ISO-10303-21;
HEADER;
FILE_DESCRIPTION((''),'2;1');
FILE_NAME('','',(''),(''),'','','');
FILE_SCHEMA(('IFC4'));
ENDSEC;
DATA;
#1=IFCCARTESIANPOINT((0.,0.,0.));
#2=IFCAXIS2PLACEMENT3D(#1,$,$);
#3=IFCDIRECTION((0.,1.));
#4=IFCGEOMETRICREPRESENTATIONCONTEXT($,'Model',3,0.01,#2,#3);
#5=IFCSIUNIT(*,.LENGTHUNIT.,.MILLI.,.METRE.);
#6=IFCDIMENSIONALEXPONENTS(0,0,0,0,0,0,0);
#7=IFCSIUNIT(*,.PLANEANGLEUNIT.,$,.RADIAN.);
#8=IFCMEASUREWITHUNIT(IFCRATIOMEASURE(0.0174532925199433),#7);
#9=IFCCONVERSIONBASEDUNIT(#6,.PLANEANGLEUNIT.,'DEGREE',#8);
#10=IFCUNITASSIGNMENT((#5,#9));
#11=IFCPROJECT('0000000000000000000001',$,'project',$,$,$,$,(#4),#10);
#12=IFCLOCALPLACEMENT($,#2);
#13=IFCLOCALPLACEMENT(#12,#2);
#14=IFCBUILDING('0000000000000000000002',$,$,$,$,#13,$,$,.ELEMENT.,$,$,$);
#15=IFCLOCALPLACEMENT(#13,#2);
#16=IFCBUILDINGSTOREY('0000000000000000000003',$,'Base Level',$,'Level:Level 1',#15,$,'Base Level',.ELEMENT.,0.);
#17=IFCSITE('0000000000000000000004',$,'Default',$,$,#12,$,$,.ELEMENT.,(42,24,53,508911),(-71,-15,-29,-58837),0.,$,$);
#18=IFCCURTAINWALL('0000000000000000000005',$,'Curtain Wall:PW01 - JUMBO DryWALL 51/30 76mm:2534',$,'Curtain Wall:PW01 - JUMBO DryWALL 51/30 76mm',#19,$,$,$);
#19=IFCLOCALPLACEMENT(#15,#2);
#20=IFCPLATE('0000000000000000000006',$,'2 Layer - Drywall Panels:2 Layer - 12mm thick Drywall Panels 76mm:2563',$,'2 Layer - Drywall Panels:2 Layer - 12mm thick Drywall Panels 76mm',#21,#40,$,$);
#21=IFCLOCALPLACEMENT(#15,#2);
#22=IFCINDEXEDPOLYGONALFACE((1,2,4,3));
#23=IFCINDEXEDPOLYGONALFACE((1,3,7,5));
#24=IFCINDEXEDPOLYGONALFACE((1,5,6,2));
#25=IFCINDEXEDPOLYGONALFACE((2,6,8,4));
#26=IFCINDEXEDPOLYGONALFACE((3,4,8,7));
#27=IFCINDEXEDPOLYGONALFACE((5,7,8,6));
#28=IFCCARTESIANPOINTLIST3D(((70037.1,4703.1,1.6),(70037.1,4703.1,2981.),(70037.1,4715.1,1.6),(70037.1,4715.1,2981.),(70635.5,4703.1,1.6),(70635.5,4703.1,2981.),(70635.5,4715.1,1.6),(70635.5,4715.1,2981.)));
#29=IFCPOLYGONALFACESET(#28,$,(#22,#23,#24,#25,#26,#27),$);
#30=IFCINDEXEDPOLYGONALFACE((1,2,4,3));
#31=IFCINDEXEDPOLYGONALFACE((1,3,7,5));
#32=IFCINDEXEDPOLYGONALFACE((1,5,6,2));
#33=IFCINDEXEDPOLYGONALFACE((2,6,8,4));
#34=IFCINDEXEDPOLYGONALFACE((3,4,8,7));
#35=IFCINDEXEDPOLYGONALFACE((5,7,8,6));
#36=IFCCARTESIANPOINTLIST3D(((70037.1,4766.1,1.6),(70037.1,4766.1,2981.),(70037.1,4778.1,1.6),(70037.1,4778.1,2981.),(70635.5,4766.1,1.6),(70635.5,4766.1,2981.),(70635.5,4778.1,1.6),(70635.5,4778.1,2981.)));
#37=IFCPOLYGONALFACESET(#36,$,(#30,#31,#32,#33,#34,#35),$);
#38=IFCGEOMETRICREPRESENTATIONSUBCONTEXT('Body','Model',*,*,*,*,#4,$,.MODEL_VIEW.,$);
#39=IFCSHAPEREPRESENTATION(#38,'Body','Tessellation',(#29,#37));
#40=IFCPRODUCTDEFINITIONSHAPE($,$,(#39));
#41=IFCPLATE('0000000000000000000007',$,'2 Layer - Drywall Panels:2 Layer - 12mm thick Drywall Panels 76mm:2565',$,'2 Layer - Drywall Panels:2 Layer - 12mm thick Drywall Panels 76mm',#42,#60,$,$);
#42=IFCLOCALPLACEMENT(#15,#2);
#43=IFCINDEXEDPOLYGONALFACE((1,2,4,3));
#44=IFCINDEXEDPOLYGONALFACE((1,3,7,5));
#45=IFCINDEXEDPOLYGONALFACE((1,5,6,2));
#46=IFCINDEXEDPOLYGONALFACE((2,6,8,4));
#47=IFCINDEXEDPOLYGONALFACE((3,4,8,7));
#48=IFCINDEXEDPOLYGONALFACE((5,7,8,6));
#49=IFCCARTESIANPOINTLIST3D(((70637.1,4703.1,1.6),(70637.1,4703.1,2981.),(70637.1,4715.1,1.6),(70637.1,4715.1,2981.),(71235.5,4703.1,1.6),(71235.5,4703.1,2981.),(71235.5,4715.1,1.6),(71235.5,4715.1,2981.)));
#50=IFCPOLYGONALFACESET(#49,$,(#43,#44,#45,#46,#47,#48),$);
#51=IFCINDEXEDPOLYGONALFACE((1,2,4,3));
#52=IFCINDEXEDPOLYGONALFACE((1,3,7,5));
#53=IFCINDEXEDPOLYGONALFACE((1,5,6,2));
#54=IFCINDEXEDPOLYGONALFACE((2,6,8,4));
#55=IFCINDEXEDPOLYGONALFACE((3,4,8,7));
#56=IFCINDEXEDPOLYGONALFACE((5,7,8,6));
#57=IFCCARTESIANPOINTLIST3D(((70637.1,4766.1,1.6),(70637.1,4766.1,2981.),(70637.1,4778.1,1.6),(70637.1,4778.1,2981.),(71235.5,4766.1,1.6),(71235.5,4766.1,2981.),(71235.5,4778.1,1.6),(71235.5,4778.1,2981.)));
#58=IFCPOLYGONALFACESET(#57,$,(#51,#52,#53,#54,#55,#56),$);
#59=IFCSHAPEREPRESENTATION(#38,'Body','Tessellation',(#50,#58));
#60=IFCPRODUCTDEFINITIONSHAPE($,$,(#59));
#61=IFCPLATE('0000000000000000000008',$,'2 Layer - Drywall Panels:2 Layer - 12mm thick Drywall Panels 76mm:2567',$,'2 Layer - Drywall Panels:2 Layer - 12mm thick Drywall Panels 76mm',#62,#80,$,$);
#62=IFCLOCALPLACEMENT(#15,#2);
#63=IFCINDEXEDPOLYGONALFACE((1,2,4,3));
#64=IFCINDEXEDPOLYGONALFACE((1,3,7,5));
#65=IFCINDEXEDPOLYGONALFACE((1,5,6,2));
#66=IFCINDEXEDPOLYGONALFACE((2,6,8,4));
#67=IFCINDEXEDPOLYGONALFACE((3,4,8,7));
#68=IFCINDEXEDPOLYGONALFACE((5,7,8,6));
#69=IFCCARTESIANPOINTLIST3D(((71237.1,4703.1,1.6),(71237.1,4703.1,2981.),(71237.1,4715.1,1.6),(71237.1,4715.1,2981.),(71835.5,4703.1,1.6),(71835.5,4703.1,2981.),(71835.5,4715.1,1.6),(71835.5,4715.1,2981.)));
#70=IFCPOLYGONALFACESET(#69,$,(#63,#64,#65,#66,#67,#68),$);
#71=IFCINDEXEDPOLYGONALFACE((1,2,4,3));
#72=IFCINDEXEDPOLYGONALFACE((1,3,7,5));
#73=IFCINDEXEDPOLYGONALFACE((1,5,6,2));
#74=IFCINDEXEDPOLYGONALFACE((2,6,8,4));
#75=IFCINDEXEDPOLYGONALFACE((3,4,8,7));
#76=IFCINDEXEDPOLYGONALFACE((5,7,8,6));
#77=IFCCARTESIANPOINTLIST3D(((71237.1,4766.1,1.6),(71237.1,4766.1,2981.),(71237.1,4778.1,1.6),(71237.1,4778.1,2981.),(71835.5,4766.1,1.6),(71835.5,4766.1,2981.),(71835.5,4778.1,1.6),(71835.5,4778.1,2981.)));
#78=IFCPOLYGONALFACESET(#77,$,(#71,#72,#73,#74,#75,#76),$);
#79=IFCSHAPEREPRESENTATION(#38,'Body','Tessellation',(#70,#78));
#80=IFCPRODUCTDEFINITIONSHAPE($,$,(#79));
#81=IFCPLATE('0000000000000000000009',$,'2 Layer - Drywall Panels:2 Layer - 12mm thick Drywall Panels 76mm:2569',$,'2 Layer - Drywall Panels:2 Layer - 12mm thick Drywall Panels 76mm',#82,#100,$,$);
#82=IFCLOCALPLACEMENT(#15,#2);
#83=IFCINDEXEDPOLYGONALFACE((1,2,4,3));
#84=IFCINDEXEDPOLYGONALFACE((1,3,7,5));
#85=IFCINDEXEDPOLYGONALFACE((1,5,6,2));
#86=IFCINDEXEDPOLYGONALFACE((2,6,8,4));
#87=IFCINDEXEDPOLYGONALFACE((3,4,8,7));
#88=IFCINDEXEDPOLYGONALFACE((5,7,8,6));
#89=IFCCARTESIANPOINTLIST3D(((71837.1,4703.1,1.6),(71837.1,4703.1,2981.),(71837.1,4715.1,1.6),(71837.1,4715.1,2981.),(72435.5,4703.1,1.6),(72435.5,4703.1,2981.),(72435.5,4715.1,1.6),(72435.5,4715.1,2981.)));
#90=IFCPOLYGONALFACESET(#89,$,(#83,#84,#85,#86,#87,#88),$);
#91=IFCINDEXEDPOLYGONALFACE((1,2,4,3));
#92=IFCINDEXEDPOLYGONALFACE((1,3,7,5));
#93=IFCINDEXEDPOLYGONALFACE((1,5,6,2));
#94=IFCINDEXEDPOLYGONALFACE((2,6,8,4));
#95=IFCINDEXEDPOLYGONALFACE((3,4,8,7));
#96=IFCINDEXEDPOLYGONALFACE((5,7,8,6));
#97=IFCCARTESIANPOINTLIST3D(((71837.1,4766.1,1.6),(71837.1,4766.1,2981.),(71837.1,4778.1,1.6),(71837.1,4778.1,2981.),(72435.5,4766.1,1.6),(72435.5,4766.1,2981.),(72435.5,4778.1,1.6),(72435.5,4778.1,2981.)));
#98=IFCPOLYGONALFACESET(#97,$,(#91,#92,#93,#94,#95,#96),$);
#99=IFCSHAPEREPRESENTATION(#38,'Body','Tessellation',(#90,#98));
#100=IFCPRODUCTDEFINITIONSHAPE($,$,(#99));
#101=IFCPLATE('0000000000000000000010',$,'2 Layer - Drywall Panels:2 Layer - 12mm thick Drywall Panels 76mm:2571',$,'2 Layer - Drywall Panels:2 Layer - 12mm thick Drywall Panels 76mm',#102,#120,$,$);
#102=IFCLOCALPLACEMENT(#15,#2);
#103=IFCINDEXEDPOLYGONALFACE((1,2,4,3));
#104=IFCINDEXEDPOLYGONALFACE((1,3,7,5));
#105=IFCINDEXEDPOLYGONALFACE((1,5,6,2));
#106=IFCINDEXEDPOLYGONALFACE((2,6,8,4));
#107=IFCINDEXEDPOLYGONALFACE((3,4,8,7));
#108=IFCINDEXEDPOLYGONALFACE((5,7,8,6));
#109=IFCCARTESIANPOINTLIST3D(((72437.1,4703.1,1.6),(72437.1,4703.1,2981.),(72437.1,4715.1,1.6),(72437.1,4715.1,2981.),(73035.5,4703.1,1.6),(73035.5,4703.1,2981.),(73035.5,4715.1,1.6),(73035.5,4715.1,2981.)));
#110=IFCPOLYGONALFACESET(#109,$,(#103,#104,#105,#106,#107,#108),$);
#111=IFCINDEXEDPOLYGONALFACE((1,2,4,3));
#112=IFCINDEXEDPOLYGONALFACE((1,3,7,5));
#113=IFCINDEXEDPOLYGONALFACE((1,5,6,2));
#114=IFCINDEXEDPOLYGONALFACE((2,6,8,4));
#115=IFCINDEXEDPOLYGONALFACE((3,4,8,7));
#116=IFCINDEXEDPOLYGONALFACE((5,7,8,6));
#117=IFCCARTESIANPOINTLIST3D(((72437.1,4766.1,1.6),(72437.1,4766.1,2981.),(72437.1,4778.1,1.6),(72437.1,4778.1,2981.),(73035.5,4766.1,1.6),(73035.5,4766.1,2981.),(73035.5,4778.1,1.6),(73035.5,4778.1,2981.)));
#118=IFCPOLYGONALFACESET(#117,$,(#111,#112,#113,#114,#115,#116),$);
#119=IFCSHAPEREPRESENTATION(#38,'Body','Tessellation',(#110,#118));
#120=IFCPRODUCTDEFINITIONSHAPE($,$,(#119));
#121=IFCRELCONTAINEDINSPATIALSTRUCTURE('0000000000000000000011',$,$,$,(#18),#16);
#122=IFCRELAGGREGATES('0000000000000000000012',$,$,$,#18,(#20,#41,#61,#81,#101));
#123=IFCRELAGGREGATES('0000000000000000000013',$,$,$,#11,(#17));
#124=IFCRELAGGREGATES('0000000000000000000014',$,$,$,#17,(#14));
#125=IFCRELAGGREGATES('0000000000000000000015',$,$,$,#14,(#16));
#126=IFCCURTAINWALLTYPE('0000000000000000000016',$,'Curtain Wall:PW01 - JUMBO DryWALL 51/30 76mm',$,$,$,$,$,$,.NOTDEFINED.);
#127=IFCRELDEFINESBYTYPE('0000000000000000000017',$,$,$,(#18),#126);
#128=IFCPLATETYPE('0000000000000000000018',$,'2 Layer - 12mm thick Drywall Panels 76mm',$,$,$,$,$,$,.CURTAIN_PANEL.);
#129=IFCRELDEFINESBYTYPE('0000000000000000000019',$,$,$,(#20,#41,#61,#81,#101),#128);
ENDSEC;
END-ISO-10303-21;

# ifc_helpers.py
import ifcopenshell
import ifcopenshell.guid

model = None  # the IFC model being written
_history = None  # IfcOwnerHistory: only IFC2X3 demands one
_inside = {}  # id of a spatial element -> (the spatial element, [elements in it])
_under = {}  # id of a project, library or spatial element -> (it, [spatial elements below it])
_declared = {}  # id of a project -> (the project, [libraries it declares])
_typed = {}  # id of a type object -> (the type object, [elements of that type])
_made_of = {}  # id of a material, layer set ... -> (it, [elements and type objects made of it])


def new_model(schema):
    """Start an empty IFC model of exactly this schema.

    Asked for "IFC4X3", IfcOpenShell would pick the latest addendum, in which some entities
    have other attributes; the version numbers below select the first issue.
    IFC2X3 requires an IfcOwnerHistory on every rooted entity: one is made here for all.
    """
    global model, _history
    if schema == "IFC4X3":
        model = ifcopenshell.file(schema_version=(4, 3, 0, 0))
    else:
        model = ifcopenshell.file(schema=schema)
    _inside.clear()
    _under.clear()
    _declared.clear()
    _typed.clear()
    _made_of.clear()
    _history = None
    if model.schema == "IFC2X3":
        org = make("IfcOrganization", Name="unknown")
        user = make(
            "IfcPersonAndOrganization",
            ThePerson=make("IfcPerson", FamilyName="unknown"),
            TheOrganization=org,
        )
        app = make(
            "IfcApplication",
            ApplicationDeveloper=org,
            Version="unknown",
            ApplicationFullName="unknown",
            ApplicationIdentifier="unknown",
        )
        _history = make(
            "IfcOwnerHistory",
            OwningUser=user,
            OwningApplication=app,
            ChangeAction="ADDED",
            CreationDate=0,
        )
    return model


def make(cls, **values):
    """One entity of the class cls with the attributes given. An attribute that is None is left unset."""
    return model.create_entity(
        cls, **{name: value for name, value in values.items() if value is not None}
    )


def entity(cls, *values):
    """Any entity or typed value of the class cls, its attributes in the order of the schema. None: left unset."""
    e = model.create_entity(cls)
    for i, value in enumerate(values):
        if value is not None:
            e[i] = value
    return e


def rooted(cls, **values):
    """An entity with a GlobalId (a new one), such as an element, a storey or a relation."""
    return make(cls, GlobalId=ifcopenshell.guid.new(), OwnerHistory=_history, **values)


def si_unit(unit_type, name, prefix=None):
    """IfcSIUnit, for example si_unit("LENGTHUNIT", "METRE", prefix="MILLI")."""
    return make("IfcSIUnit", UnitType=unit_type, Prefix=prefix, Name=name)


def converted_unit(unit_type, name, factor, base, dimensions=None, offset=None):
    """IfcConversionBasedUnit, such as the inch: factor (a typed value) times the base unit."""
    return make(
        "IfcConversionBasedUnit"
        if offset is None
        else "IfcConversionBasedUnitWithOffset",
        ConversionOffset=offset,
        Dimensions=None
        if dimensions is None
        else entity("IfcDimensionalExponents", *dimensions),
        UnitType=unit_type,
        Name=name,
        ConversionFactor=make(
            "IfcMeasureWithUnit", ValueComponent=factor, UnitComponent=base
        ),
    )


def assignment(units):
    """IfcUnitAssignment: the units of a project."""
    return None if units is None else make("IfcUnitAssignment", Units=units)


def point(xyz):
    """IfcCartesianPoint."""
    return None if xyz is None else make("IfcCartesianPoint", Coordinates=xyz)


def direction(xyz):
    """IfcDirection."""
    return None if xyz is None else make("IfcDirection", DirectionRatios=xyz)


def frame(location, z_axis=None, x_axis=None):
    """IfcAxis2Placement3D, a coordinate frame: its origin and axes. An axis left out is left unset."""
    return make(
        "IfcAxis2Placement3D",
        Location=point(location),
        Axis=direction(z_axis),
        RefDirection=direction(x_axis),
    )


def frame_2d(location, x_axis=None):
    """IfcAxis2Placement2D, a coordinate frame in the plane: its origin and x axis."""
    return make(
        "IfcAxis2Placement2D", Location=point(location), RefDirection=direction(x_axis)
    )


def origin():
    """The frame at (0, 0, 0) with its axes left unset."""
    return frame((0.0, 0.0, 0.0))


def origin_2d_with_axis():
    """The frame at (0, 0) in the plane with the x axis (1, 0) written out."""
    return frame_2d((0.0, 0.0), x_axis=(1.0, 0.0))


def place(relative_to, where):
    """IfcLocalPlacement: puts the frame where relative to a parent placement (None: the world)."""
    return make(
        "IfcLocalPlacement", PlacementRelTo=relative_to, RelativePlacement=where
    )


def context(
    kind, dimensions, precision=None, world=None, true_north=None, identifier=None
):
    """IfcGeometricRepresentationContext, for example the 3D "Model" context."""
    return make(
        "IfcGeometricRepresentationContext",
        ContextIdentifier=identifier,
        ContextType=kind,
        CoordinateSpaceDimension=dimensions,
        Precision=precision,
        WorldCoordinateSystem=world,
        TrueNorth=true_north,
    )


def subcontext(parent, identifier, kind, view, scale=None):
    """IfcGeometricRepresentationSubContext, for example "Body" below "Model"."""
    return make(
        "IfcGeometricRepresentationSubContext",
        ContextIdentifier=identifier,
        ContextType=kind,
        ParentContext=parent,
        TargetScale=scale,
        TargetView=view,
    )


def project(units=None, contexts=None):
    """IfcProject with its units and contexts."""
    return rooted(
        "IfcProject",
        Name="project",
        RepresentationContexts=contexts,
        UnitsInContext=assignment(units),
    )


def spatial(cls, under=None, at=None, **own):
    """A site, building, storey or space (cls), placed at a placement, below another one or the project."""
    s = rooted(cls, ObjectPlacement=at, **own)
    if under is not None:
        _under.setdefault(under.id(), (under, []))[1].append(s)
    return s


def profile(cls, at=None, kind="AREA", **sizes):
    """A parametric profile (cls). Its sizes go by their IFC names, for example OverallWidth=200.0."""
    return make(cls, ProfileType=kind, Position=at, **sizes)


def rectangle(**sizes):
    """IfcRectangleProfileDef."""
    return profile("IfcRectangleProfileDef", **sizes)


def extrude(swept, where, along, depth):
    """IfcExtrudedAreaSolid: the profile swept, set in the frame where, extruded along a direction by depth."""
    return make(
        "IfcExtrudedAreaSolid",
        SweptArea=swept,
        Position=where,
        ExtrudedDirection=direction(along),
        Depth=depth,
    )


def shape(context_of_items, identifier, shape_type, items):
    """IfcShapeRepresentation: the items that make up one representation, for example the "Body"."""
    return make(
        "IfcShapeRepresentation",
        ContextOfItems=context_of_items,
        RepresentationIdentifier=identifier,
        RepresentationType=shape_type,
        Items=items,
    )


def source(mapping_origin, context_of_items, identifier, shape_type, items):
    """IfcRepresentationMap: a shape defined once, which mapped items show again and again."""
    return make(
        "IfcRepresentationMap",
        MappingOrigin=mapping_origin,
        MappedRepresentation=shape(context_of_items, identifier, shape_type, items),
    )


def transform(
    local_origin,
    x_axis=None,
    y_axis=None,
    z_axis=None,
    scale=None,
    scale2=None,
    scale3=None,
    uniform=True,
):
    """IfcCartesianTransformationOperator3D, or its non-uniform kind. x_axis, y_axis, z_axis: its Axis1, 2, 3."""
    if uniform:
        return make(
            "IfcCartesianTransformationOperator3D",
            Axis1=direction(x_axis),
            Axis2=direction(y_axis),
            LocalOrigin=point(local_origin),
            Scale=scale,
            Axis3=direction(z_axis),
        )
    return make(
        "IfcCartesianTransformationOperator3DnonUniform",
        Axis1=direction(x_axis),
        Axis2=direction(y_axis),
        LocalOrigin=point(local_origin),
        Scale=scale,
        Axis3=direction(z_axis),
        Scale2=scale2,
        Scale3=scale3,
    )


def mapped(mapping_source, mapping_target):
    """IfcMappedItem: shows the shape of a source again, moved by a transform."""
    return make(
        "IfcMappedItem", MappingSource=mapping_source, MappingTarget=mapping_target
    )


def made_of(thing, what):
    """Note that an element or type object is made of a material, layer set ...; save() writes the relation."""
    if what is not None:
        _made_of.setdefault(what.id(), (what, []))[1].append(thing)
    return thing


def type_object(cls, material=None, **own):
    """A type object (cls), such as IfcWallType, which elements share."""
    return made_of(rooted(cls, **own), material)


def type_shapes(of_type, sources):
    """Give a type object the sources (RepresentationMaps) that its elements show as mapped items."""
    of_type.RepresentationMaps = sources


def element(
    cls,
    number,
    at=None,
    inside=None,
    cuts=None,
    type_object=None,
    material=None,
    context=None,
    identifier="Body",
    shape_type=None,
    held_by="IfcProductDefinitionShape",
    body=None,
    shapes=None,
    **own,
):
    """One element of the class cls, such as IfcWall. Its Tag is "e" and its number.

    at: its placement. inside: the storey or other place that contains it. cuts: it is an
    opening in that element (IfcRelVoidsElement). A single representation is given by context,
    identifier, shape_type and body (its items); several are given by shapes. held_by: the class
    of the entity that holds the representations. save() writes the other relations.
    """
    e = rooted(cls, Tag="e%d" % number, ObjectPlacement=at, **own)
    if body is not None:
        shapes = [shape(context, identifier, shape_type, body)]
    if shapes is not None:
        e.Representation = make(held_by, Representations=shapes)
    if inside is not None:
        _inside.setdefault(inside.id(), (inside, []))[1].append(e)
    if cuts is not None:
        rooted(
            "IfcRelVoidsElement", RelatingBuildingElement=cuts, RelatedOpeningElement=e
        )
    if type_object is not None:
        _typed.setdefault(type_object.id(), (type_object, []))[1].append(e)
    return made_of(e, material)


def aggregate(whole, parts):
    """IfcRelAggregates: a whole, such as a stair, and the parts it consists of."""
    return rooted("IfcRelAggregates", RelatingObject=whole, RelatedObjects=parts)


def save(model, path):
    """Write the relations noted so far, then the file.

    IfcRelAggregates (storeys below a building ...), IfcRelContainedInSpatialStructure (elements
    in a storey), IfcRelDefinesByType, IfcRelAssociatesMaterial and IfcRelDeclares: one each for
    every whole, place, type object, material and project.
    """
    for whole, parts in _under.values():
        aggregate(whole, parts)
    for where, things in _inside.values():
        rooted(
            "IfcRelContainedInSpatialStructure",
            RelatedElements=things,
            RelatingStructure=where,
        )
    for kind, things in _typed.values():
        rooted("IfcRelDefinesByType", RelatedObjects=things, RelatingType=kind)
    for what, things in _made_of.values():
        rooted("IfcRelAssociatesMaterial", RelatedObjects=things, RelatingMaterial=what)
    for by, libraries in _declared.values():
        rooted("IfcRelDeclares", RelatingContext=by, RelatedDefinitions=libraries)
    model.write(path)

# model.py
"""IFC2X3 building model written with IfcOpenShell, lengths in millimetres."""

from ifc_helpers import new_model, entity, si_unit, converted_unit, direction, frame, frame_2d, origin, origin_2d_with_axis, place, context, subcontext, project, spatial, rectangle, extrude, source, transform, mapped, type_object, type_shapes, element, aggregate, save


model = new_model("IFC2X3")

# Units and contexts
model_context = context("Model", 3, precision=0.01, world=origin(), true_north=direction((0.0, 1.0)))
body_context = subcontext(model_context, "Body", "Model", "MODEL_VIEW")
ifc_project = project(units=[si_unit("LENGTHUNIT", "METRE", prefix="MILLI"), converted_unit("PLANEANGLEUNIT", "DEGREE", entity("IfcRatioMeasure", 0.0174532925199433), si_unit("PLANEANGLEUNIT", "RADIAN"), dimensions=[0, 0, 0, 0, 0, 0, 0])], contexts=[model_context])

# Site, building, storey
site_placement = place(None, origin())
site = spatial("IfcSite", under=ifc_project, at=site_placement, Name="Default", CompositionType="ELEMENT", RefLatitude=(42, 24, 53, 508911), RefLongitude=(-71, -15, -29, -58837), RefElevation=0.0)
building_placement = place(site_placement, origin())
building = spatial("IfcBuilding", under=site, at=building_placement, CompositionType="ELEMENT")
storey_placement = place(building_placement, origin())
storey = spatial("IfcBuildingStorey", under=building, at=storey_placement, Name="Base Level", ObjectType="Level:Level 1", LongName="Base Level", CompositionType="ELEMENT", Elevation=0.0)

# Curtain wall, plates
curtain_wall_type = type_object("IfcCurtainWallType", Name="Curtain Wall:PW01 - JUMBO DryWALL 51/30 76mm", PredefinedType="NOTDEFINED")
curtain_wall_placement = place(building_placement, origin())
curtain_wall = element("IfcCurtainWall", 1, at=curtain_wall_placement, inside=storey, type_object=curtain_wall_type, Name="Curtain Wall:PW01 - JUMBO DryWALL 51/30 76mm:2534", ObjectType="Curtain Wall:PW01 - JUMBO DryWALL 51/30 76mm")
plate_type = type_object("IfcPlateType", Name="2 Layer - 12mm thick Drywall Panels 76mm", PredefinedType="CURTAIN_PANEL")
shared_shape_1 = source(origin(), body_context, "Body", "SweptSolid", [
    extrude(rectangle(XDim=598.4, YDim=12.0, at=origin_2d_with_axis()), frame((0.0, -31.5, 0.0), z_axis=(0.0, 0.0, 1.0), x_axis=(-1.0, 0.0, 0.0)), (0.0, 0.0, 1.0), 2979.4),
    extrude(rectangle(XDim=12.0, YDim=598.4, at=frame_2d((0.0, 0.0), x_axis=(1.0, 0.0))), frame((0.0, 31.5, 0.0), z_axis=(0.0, 0.0, 1.0), x_axis=(0.0, 1.0, 0.0)), (0.0, 0.0, 1.0), 2979.4),
])
type_shapes(plate_type, [shared_shape_1])
plate_1_placement = place(curtain_wall_placement, frame((70336.3, 4740.6, 1.6)))
plate_1 = element("IfcPlate", 2, at=plate_1_placement, type_object=plate_type, Name="2 Layer - Drywall Panels:2 Layer - 12mm thick Drywall Panels 76mm:2563", ObjectType="2 Layer - Drywall Panels:2 Layer - 12mm thick Drywall Panels 76mm", context=body_context, shape_type="MappedRepresentation", body=[
    mapped(shared_shape_1, transform((0.0, 0.0, 0.0), scale=1.0)),
])
plate_2_placement = place(curtain_wall_placement, frame((70936.3, 4740.6, 1.6)))
plate_2 = element("IfcPlate", 3, at=plate_2_placement, type_object=plate_type, Name="2 Layer - Drywall Panels:2 Layer - 12mm thick Drywall Panels 76mm:2565", ObjectType="2 Layer - Drywall Panels:2 Layer - 12mm thick Drywall Panels 76mm", context=body_context, shape_type="MappedRepresentation", body=[
    mapped(shared_shape_1, transform((0.0, 0.0, 0.0), scale=1.0)),
])
plate_3_placement = place(curtain_wall_placement, frame((71536.3, 4740.6, 1.6)))
plate_3 = element("IfcPlate", 4, at=plate_3_placement, type_object=plate_type, Name="2 Layer - Drywall Panels:2 Layer - 12mm thick Drywall Panels 76mm:2567", ObjectType="2 Layer - Drywall Panels:2 Layer - 12mm thick Drywall Panels 76mm", context=body_context, shape_type="MappedRepresentation", body=[
    mapped(shared_shape_1, transform((0.0, 0.0, 0.0), scale=1.0)),
])
plate_4_placement = place(curtain_wall_placement, frame((72136.3, 4740.6, 1.6)))
plate_4 = element("IfcPlate", 5, at=plate_4_placement, type_object=plate_type, Name="2 Layer - Drywall Panels:2 Layer - 12mm thick Drywall Panels 76mm:2569", ObjectType="2 Layer - Drywall Panels:2 Layer - 12mm thick Drywall Panels 76mm", context=body_context, shape_type="MappedRepresentation", body=[
    mapped(shared_shape_1, transform((0.0, 0.0, 0.0), scale=1.0)),
])
plate_5_placement = place(curtain_wall_placement, frame((72736.3, 4740.6, 1.6)))
plate_5 = element("IfcPlate", 6, at=plate_5_placement, type_object=plate_type, Name="2 Layer - Drywall Panels:2 Layer - 12mm thick Drywall Panels 76mm:2571", ObjectType="2 Layer - Drywall Panels:2 Layer - 12mm thick Drywall Panels 76mm", context=body_context, shape_type="MappedRepresentation", body=[
    mapped(shared_shape_1, transform((0.0, 0.0, 0.0), scale=1.0)),
])
aggregate(curtain_wall, [plate_1, plate_2, plate_3, plate_4, plate_5])

save(model, "model.ifc")
